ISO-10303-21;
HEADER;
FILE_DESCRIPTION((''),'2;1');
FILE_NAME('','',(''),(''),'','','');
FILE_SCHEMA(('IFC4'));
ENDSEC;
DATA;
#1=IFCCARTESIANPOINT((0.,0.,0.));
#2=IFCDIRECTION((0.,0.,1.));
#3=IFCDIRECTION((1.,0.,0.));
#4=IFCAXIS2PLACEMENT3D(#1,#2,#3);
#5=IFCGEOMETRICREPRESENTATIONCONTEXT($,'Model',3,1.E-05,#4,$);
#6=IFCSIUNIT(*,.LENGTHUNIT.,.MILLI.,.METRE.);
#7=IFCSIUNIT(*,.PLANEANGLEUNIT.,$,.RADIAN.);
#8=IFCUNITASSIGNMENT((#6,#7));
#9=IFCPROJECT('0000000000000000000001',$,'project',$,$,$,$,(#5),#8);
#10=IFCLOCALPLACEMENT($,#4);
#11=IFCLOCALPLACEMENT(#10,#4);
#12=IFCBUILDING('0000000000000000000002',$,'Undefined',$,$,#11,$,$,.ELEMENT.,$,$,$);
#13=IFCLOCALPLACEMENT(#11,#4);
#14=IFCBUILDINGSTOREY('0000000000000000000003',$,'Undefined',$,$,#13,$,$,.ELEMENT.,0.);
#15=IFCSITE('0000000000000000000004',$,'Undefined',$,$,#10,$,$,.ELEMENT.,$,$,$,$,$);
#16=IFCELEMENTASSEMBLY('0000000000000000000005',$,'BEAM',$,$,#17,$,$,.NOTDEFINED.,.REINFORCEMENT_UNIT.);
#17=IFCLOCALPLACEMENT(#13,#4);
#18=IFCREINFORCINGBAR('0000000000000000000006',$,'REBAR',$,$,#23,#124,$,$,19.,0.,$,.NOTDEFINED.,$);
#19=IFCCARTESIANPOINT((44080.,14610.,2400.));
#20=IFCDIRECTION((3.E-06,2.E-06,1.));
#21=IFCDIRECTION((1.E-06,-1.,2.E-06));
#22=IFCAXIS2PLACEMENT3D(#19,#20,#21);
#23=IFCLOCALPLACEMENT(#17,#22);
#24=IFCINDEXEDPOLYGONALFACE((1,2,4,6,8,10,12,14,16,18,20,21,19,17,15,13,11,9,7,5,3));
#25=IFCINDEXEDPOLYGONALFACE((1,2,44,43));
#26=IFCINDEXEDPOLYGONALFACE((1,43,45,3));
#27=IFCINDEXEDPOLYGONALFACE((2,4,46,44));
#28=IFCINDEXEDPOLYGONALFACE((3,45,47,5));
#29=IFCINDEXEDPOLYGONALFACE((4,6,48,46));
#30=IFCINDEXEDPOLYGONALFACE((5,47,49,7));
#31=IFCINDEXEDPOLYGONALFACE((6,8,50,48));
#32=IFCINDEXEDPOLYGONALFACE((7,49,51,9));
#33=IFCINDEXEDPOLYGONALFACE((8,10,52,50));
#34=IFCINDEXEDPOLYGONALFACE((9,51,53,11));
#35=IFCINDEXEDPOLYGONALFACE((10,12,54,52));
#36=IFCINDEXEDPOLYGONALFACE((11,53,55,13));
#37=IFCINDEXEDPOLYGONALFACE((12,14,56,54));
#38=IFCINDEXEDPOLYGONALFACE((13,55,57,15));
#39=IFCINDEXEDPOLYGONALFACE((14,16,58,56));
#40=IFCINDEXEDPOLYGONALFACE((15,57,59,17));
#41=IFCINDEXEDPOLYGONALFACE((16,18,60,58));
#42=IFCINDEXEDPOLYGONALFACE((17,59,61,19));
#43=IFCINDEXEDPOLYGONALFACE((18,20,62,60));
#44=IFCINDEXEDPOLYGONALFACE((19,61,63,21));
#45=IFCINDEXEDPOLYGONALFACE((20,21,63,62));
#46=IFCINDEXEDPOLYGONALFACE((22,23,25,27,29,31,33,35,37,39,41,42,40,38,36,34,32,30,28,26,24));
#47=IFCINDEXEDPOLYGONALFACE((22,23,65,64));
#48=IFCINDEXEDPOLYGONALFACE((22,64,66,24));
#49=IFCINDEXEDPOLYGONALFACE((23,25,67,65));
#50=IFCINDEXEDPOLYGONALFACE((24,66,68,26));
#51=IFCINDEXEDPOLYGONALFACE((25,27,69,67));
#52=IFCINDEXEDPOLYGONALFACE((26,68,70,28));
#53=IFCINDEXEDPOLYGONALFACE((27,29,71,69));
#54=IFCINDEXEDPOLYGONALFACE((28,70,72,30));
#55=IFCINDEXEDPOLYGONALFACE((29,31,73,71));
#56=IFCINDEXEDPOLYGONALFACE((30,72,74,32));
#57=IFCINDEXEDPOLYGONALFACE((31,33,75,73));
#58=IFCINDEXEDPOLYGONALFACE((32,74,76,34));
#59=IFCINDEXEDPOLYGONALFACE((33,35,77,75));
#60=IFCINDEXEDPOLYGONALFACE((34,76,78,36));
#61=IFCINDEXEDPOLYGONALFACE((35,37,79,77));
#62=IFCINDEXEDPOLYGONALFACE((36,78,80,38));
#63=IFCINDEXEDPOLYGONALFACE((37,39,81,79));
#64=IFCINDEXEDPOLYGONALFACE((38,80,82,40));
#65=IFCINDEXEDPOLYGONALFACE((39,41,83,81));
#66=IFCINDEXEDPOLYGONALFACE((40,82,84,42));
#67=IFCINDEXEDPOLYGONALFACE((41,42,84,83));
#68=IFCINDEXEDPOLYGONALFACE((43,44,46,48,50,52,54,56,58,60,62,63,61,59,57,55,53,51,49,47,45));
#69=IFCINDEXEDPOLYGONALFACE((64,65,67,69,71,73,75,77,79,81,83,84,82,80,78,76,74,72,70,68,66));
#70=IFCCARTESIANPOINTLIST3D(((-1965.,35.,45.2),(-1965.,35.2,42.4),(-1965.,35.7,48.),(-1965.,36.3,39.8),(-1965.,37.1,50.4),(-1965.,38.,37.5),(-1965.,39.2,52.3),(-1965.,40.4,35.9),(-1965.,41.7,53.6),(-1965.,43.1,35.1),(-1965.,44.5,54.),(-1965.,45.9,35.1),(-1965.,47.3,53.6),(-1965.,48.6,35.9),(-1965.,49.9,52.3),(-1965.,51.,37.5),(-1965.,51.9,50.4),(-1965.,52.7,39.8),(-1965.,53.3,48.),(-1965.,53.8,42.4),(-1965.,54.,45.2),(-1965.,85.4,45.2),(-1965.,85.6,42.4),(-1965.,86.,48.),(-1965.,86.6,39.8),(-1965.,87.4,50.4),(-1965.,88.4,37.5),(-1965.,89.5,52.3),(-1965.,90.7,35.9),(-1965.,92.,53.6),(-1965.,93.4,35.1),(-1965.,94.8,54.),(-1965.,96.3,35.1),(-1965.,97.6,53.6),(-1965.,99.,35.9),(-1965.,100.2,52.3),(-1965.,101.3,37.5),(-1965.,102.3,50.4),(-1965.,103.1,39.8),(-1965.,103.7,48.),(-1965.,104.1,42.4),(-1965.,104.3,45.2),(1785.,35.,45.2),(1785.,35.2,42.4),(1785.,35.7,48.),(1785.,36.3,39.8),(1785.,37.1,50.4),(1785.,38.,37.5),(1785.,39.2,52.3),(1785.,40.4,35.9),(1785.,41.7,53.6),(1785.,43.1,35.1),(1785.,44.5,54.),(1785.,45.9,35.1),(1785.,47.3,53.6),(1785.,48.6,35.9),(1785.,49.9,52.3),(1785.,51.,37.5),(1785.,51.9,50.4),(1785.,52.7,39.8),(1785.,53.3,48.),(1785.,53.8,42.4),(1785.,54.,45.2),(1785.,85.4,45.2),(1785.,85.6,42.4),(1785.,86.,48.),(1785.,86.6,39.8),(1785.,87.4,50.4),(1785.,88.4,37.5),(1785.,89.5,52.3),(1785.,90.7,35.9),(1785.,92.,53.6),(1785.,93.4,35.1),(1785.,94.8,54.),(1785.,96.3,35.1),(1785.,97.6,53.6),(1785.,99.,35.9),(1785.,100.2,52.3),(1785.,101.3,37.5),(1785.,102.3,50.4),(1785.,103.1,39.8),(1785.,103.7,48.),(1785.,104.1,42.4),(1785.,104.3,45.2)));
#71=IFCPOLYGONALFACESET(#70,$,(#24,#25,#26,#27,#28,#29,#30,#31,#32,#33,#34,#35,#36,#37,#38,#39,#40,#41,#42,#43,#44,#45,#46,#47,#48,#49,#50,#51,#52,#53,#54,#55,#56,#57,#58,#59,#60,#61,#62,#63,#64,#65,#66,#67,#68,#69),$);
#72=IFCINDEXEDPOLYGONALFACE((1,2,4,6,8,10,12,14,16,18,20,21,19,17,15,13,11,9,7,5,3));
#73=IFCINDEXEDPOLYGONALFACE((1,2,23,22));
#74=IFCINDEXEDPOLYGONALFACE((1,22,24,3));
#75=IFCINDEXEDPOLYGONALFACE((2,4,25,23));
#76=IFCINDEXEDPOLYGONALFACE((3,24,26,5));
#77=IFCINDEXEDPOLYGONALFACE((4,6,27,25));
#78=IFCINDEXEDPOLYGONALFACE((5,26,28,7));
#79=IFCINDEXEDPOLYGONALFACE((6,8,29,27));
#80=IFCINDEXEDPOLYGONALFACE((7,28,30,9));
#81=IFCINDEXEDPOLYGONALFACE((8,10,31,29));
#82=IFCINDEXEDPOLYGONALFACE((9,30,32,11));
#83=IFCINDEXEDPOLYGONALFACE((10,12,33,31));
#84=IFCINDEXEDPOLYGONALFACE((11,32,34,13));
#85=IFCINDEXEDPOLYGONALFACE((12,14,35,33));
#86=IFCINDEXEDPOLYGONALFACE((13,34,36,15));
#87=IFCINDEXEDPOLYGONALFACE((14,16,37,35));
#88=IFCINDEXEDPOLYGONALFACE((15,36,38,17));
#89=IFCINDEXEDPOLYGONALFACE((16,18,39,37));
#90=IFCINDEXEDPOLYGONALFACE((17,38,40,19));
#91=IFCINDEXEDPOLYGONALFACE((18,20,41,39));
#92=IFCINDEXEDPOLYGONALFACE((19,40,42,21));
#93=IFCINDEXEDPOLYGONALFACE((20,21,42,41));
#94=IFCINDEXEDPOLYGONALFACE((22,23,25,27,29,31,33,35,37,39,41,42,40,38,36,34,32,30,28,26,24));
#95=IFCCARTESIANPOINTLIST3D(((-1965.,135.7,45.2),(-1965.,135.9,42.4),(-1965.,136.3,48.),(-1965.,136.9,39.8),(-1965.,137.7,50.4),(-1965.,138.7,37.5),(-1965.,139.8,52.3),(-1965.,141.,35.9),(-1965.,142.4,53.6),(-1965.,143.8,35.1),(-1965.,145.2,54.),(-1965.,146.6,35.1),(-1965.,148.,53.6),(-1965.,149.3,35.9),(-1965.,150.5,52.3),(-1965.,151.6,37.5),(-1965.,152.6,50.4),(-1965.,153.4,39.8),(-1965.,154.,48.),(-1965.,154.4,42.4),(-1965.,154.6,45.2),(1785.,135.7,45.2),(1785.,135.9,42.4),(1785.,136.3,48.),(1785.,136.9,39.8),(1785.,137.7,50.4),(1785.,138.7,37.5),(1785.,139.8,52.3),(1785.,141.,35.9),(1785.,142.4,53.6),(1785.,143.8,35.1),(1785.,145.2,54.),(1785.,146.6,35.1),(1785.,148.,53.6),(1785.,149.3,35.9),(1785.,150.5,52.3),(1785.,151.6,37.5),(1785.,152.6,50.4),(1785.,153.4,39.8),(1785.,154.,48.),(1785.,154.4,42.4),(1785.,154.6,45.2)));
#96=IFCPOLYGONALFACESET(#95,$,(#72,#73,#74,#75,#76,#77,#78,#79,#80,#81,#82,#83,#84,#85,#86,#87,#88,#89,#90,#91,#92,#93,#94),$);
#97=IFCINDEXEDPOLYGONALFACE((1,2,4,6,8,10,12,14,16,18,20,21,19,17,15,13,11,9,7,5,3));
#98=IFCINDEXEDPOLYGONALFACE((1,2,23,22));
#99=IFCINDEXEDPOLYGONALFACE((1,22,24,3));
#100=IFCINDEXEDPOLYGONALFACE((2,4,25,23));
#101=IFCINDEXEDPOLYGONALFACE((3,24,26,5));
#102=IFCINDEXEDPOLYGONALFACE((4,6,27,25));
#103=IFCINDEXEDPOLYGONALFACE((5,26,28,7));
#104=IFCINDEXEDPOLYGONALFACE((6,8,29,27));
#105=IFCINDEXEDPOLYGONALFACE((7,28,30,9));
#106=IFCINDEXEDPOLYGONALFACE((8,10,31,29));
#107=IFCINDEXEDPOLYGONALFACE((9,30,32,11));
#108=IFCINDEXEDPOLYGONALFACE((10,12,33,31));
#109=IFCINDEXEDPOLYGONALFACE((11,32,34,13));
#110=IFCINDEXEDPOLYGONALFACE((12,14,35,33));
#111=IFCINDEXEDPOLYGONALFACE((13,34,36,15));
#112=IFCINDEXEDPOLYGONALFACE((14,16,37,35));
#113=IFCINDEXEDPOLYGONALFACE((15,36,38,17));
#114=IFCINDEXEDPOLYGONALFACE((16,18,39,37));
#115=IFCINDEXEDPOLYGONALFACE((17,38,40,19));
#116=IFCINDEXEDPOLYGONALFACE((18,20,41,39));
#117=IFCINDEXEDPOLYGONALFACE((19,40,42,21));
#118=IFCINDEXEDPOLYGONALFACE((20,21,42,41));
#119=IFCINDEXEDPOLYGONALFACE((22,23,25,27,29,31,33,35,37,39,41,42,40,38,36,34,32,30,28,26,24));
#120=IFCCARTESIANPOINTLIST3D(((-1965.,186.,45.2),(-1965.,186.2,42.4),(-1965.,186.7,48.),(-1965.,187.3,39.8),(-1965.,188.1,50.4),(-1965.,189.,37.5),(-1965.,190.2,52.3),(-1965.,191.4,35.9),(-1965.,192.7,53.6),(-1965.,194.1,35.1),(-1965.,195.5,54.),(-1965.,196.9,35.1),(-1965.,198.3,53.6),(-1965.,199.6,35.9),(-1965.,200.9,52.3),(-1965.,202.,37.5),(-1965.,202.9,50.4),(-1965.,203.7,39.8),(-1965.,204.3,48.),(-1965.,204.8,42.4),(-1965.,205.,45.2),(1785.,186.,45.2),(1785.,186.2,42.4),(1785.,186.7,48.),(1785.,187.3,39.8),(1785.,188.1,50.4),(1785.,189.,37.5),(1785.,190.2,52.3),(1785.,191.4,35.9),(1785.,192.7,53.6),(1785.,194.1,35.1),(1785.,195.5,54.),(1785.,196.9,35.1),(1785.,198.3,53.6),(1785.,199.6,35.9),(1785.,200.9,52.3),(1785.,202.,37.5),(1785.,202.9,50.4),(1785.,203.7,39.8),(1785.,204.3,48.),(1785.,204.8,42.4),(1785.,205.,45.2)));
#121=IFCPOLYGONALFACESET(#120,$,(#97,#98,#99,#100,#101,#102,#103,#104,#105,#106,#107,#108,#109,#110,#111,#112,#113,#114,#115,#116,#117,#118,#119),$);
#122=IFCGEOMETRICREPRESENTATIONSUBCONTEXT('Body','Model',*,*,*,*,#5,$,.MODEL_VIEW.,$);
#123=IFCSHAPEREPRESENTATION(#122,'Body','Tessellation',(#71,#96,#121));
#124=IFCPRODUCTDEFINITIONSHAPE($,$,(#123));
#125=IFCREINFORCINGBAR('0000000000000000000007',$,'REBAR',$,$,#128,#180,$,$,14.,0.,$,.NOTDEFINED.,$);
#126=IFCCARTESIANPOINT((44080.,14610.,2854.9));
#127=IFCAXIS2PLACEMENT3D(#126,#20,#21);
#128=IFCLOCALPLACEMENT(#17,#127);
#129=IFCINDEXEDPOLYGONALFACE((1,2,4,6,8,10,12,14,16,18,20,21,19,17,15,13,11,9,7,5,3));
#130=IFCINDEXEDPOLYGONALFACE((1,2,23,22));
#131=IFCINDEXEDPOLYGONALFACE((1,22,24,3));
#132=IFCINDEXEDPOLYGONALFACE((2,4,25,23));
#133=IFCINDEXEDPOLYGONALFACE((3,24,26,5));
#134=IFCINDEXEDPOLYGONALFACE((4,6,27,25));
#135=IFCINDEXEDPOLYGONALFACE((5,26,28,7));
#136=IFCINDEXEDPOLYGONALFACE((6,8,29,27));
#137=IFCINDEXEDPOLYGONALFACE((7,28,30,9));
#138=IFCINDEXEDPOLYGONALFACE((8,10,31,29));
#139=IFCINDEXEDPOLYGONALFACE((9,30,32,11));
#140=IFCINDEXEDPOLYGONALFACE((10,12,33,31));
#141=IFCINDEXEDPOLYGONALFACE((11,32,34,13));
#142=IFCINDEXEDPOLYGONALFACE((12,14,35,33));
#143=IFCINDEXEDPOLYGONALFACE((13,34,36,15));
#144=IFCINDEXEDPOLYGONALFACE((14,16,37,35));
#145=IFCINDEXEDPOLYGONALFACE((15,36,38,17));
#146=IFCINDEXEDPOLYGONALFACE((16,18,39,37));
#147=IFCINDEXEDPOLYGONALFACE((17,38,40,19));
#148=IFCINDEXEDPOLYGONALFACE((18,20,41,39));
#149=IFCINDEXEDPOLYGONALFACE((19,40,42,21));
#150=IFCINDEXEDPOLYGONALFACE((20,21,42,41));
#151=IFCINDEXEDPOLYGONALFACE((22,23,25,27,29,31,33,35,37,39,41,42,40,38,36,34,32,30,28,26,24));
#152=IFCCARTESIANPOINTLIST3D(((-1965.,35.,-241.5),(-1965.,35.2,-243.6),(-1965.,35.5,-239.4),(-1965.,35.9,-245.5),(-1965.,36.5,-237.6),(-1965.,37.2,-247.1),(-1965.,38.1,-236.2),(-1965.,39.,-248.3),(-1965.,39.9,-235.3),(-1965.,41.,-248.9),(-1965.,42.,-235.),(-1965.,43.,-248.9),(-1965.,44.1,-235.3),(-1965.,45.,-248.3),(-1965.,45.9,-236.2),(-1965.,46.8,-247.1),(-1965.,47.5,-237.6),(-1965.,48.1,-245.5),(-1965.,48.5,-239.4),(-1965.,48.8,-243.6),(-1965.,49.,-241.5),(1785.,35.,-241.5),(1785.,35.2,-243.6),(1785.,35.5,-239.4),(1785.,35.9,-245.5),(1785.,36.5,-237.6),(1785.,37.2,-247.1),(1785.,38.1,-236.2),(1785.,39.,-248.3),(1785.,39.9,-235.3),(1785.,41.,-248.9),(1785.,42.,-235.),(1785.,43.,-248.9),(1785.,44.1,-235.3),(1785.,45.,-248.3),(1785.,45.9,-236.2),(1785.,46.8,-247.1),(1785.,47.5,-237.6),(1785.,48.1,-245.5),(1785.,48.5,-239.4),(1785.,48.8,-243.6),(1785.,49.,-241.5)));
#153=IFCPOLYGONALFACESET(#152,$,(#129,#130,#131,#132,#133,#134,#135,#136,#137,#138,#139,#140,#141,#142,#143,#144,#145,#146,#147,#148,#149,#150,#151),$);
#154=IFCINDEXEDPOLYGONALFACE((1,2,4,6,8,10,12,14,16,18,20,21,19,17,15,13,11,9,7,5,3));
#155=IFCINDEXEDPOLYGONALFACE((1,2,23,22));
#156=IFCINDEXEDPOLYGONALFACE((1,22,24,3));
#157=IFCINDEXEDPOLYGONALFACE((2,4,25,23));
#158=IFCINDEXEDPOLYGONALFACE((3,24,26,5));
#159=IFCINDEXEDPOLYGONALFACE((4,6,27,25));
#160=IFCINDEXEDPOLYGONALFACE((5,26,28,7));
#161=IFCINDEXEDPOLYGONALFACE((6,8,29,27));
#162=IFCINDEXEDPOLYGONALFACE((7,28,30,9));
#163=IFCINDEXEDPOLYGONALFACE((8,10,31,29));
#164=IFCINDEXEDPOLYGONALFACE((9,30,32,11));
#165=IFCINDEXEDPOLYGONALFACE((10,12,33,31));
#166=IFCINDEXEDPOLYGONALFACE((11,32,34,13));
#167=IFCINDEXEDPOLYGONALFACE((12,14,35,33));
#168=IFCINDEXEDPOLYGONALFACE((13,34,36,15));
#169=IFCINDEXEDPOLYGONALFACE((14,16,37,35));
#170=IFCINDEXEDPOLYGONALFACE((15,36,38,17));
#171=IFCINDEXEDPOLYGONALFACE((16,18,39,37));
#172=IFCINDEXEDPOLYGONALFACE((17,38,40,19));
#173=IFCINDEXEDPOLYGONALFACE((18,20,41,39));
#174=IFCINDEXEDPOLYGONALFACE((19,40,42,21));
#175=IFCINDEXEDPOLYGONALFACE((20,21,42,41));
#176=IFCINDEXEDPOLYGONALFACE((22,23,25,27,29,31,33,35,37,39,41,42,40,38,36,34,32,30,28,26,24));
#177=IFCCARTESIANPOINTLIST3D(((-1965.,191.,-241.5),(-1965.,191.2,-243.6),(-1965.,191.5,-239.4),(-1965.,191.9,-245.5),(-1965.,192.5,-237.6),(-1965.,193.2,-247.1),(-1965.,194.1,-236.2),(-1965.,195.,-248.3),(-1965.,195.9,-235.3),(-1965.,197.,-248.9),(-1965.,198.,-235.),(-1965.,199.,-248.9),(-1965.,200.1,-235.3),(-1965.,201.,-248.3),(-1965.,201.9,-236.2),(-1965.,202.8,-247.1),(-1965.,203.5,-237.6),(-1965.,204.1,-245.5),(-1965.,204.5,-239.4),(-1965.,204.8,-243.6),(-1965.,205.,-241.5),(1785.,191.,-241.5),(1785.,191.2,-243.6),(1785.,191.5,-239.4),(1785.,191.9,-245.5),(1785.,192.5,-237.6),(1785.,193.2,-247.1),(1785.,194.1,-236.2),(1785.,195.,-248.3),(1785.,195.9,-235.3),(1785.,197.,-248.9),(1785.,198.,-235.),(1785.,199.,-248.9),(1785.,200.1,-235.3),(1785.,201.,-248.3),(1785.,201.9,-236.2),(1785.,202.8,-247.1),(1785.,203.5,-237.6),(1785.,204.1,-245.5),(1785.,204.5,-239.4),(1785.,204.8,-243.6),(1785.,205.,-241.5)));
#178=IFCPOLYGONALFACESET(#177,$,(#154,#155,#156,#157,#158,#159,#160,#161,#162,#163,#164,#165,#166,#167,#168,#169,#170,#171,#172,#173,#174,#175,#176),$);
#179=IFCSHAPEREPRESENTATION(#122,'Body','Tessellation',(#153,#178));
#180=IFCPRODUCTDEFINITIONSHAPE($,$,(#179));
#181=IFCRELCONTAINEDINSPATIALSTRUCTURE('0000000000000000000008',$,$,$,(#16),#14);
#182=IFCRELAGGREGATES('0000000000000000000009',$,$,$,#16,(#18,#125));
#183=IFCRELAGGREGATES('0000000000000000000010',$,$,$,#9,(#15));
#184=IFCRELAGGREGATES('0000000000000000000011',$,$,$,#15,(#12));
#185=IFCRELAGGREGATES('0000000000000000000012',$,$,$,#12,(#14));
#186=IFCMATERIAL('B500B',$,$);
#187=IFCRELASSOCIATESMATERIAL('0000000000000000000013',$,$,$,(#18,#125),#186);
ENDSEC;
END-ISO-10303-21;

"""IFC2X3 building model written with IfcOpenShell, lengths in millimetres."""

from ifc_helpers import new_model, entity, si_unit, frame, origin_with_axes, place, context, subcontext, project, spatial, source, transform, mapped, material, element, aggregate, save


model = new_model("IFC2X3")

# Units and contexts
model_context = context("Model", 3, precision=1e-05, world=origin_with_axes())
body_context = subcontext(model_context, "Body", "Model", "MODEL_VIEW")
ifc_project = project(units=[si_unit("LENGTHUNIT", "METRE", prefix="MILLI"), si_unit("PLANEANGLEUNIT", "RADIAN")], contexts=[model_context])

# Site, building, storey
site_placement = place(None, origin_with_axes())
site = spatial("IfcSite", under=ifc_project, at=site_placement, Name="Undefined", CompositionType="ELEMENT")
building_placement = place(site_placement, origin_with_axes())
building = spatial("IfcBuilding", under=site, at=building_placement, Name="Undefined", CompositionType="ELEMENT")
storey_placement = place(building_placement, origin_with_axes())
storey = spatial("IfcBuildingStorey", under=building, at=storey_placement, Name="Undefined", CompositionType="ELEMENT", Elevation=0.0)

# Shared definitions
ifc_material_1 = material(Name="B500B")

# Element assembly, reinforcing bars
assembly_1_placement = place(storey_placement, origin_with_axes())
assembly_1 = element("IfcElementAssembly", 1, at=assembly_1_placement, inside=storey, Name="BEAM", AssemblyPlace="NOTDEFINED", PredefinedType="REINFORCEMENT_UNIT")
shared_shape_1 = source(origin_with_axes(), body_context, "Body", "AdvancedSweptSolid", [
    entity("IfcSweptDiskSolid", entity("IfcTrimmedCurve", entity("IfcLine", entity("IfcCartesianPoint", [0.0, 0.0, 0.0]), entity("IfcVector", entity("IfcDirection", [1.0, 0.0, 0.0]), 1.0)), [entity("IfcParameterValue", 0.0)], [entity("IfcParameterValue", 3750.009616)], True, "PARAMETER"), 9.5, None, 0.0, 3750.0),
])
shared_shape_2 = source(origin_with_axes(), body_context, "Body", "AdvancedSweptSolid", [
    entity("IfcSweptDiskSolid", entity("IfcTrimmedCurve", entity("IfcLine", entity("IfcCartesianPoint", [0.0, 0.0, 0.0]), entity("IfcVector", entity("IfcDirection", [1.0, 0.0, 0.0]), 1.0)), [entity("IfcParameterValue", 0.0)], [entity("IfcParameterValue", 3750.009616)], True, "PARAMETER"), 9.5, None, 0.0, 3750.0),
])
shared_shape_3 = source(origin_with_axes(), body_context, "Body", "AdvancedSweptSolid", [
    entity("IfcSweptDiskSolid", entity("IfcTrimmedCurve", entity("IfcLine", entity("IfcCartesianPoint", [0.0, 0.0, 0.0]), entity("IfcVector", entity("IfcDirection", [1.0, 0.0, 0.0]), 1.0)), [entity("IfcParameterValue", 0.0)], [entity("IfcParameterValue", 3750.009616)], True, "PARAMETER"), 9.5, None, 0.0, 3750.0),
])
shared_shape_4 = source(origin_with_axes(), body_context, "Body", "AdvancedSweptSolid", [
    entity("IfcSweptDiskSolid", entity("IfcTrimmedCurve", entity("IfcLine", entity("IfcCartesianPoint", [0.0, 0.0, 0.0]), entity("IfcVector", entity("IfcDirection", [1.0, 0.0, 0.0]), 1.0)), [entity("IfcParameterValue", 0.0)], [entity("IfcParameterValue", 3750.009616)], True, "PARAMETER"), 9.5, None, 0.0, 3750.0),
])
reinforcing_bar_1_placement = place(assembly_1_placement, frame((44080.0, 14610.0, 2400.0), z_axis=(0.000003, 0.000002, 1.0), x_axis=(0.000001, -1.0, 0.000002)))
reinforcing_bar_1 = element("IfcReinforcingBar", 2, at=reinforcing_bar_1_placement, material=ifc_material_1, Name="REBAR", BarRole="NOTDEFINED", CrossSectionArea=0.0, NominalDiameter=19.0, context=body_context, shape_type="MappedRepresentation", body=[
    mapped(shared_shape_1, transform((-1965.0, 44.5, 44.5))),
    mapped(shared_shape_2, transform((-1965.0, 94.8, 44.5))),
    mapped(shared_shape_3, transform((-1965.0, 145.2, 44.5))),
    mapped(shared_shape_4, transform((-1965.0, 195.5, 44.5))),
])
shared_shape_5 = source(origin_with_axes(), body_context, "Body", "AdvancedSweptSolid", [
    entity("IfcSweptDiskSolid", entity("IfcTrimmedCurve", entity("IfcLine", entity("IfcCartesianPoint", [0.0, 0.0, 0.0]), entity("IfcVector", entity("IfcDirection", [1.0, 0.0, 0.0]), 1.0)), [entity("IfcParameterValue", 0.0)], [entity("IfcParameterValue", 3750.009616)], True, "PARAMETER"), 7.0, None, 0.0, 3750.0),
])
shared_shape_6 = source(origin_with_axes(), body_context, "Body", "AdvancedSweptSolid", [
    entity("IfcSweptDiskSolid", entity("IfcTrimmedCurve", entity("IfcLine", entity("IfcCartesianPoint", [0.0, 0.0, 0.0]), entity("IfcVector", entity("IfcDirection", [1.0, 0.0, 0.0]), 1.0)), [entity("IfcParameterValue", 0.0)], [entity("IfcParameterValue", 3750.009616)], True, "PARAMETER"), 7.0, None, 0.0, 3750.0),
])
reinforcing_bar_2_placement = place(assembly_1_placement, frame((44080.0, 14610.0, 2854.9), z_axis=(0.000003, 0.000002, 1.0), x_axis=(0.000001, -1.0, 0.000002)))
reinforcing_bar_2 = element("IfcReinforcingBar", 3, at=reinforcing_bar_2_placement, material=ifc_material_1, Name="REBAR", BarRole="NOTDEFINED", CrossSectionArea=0.0, NominalDiameter=14.0, context=body_context, shape_type="MappedRepresentation", body=[
    mapped(shared_shape_5, transform((-1965.0, 42.0, -242.0))),
    mapped(shared_shape_6, transform((-1965.0, 198.0, -242.0))),
])
aggregate(assembly_1, [reinforcing_bar_1, reinforcing_bar_2])

save(model, "model.ifc")
